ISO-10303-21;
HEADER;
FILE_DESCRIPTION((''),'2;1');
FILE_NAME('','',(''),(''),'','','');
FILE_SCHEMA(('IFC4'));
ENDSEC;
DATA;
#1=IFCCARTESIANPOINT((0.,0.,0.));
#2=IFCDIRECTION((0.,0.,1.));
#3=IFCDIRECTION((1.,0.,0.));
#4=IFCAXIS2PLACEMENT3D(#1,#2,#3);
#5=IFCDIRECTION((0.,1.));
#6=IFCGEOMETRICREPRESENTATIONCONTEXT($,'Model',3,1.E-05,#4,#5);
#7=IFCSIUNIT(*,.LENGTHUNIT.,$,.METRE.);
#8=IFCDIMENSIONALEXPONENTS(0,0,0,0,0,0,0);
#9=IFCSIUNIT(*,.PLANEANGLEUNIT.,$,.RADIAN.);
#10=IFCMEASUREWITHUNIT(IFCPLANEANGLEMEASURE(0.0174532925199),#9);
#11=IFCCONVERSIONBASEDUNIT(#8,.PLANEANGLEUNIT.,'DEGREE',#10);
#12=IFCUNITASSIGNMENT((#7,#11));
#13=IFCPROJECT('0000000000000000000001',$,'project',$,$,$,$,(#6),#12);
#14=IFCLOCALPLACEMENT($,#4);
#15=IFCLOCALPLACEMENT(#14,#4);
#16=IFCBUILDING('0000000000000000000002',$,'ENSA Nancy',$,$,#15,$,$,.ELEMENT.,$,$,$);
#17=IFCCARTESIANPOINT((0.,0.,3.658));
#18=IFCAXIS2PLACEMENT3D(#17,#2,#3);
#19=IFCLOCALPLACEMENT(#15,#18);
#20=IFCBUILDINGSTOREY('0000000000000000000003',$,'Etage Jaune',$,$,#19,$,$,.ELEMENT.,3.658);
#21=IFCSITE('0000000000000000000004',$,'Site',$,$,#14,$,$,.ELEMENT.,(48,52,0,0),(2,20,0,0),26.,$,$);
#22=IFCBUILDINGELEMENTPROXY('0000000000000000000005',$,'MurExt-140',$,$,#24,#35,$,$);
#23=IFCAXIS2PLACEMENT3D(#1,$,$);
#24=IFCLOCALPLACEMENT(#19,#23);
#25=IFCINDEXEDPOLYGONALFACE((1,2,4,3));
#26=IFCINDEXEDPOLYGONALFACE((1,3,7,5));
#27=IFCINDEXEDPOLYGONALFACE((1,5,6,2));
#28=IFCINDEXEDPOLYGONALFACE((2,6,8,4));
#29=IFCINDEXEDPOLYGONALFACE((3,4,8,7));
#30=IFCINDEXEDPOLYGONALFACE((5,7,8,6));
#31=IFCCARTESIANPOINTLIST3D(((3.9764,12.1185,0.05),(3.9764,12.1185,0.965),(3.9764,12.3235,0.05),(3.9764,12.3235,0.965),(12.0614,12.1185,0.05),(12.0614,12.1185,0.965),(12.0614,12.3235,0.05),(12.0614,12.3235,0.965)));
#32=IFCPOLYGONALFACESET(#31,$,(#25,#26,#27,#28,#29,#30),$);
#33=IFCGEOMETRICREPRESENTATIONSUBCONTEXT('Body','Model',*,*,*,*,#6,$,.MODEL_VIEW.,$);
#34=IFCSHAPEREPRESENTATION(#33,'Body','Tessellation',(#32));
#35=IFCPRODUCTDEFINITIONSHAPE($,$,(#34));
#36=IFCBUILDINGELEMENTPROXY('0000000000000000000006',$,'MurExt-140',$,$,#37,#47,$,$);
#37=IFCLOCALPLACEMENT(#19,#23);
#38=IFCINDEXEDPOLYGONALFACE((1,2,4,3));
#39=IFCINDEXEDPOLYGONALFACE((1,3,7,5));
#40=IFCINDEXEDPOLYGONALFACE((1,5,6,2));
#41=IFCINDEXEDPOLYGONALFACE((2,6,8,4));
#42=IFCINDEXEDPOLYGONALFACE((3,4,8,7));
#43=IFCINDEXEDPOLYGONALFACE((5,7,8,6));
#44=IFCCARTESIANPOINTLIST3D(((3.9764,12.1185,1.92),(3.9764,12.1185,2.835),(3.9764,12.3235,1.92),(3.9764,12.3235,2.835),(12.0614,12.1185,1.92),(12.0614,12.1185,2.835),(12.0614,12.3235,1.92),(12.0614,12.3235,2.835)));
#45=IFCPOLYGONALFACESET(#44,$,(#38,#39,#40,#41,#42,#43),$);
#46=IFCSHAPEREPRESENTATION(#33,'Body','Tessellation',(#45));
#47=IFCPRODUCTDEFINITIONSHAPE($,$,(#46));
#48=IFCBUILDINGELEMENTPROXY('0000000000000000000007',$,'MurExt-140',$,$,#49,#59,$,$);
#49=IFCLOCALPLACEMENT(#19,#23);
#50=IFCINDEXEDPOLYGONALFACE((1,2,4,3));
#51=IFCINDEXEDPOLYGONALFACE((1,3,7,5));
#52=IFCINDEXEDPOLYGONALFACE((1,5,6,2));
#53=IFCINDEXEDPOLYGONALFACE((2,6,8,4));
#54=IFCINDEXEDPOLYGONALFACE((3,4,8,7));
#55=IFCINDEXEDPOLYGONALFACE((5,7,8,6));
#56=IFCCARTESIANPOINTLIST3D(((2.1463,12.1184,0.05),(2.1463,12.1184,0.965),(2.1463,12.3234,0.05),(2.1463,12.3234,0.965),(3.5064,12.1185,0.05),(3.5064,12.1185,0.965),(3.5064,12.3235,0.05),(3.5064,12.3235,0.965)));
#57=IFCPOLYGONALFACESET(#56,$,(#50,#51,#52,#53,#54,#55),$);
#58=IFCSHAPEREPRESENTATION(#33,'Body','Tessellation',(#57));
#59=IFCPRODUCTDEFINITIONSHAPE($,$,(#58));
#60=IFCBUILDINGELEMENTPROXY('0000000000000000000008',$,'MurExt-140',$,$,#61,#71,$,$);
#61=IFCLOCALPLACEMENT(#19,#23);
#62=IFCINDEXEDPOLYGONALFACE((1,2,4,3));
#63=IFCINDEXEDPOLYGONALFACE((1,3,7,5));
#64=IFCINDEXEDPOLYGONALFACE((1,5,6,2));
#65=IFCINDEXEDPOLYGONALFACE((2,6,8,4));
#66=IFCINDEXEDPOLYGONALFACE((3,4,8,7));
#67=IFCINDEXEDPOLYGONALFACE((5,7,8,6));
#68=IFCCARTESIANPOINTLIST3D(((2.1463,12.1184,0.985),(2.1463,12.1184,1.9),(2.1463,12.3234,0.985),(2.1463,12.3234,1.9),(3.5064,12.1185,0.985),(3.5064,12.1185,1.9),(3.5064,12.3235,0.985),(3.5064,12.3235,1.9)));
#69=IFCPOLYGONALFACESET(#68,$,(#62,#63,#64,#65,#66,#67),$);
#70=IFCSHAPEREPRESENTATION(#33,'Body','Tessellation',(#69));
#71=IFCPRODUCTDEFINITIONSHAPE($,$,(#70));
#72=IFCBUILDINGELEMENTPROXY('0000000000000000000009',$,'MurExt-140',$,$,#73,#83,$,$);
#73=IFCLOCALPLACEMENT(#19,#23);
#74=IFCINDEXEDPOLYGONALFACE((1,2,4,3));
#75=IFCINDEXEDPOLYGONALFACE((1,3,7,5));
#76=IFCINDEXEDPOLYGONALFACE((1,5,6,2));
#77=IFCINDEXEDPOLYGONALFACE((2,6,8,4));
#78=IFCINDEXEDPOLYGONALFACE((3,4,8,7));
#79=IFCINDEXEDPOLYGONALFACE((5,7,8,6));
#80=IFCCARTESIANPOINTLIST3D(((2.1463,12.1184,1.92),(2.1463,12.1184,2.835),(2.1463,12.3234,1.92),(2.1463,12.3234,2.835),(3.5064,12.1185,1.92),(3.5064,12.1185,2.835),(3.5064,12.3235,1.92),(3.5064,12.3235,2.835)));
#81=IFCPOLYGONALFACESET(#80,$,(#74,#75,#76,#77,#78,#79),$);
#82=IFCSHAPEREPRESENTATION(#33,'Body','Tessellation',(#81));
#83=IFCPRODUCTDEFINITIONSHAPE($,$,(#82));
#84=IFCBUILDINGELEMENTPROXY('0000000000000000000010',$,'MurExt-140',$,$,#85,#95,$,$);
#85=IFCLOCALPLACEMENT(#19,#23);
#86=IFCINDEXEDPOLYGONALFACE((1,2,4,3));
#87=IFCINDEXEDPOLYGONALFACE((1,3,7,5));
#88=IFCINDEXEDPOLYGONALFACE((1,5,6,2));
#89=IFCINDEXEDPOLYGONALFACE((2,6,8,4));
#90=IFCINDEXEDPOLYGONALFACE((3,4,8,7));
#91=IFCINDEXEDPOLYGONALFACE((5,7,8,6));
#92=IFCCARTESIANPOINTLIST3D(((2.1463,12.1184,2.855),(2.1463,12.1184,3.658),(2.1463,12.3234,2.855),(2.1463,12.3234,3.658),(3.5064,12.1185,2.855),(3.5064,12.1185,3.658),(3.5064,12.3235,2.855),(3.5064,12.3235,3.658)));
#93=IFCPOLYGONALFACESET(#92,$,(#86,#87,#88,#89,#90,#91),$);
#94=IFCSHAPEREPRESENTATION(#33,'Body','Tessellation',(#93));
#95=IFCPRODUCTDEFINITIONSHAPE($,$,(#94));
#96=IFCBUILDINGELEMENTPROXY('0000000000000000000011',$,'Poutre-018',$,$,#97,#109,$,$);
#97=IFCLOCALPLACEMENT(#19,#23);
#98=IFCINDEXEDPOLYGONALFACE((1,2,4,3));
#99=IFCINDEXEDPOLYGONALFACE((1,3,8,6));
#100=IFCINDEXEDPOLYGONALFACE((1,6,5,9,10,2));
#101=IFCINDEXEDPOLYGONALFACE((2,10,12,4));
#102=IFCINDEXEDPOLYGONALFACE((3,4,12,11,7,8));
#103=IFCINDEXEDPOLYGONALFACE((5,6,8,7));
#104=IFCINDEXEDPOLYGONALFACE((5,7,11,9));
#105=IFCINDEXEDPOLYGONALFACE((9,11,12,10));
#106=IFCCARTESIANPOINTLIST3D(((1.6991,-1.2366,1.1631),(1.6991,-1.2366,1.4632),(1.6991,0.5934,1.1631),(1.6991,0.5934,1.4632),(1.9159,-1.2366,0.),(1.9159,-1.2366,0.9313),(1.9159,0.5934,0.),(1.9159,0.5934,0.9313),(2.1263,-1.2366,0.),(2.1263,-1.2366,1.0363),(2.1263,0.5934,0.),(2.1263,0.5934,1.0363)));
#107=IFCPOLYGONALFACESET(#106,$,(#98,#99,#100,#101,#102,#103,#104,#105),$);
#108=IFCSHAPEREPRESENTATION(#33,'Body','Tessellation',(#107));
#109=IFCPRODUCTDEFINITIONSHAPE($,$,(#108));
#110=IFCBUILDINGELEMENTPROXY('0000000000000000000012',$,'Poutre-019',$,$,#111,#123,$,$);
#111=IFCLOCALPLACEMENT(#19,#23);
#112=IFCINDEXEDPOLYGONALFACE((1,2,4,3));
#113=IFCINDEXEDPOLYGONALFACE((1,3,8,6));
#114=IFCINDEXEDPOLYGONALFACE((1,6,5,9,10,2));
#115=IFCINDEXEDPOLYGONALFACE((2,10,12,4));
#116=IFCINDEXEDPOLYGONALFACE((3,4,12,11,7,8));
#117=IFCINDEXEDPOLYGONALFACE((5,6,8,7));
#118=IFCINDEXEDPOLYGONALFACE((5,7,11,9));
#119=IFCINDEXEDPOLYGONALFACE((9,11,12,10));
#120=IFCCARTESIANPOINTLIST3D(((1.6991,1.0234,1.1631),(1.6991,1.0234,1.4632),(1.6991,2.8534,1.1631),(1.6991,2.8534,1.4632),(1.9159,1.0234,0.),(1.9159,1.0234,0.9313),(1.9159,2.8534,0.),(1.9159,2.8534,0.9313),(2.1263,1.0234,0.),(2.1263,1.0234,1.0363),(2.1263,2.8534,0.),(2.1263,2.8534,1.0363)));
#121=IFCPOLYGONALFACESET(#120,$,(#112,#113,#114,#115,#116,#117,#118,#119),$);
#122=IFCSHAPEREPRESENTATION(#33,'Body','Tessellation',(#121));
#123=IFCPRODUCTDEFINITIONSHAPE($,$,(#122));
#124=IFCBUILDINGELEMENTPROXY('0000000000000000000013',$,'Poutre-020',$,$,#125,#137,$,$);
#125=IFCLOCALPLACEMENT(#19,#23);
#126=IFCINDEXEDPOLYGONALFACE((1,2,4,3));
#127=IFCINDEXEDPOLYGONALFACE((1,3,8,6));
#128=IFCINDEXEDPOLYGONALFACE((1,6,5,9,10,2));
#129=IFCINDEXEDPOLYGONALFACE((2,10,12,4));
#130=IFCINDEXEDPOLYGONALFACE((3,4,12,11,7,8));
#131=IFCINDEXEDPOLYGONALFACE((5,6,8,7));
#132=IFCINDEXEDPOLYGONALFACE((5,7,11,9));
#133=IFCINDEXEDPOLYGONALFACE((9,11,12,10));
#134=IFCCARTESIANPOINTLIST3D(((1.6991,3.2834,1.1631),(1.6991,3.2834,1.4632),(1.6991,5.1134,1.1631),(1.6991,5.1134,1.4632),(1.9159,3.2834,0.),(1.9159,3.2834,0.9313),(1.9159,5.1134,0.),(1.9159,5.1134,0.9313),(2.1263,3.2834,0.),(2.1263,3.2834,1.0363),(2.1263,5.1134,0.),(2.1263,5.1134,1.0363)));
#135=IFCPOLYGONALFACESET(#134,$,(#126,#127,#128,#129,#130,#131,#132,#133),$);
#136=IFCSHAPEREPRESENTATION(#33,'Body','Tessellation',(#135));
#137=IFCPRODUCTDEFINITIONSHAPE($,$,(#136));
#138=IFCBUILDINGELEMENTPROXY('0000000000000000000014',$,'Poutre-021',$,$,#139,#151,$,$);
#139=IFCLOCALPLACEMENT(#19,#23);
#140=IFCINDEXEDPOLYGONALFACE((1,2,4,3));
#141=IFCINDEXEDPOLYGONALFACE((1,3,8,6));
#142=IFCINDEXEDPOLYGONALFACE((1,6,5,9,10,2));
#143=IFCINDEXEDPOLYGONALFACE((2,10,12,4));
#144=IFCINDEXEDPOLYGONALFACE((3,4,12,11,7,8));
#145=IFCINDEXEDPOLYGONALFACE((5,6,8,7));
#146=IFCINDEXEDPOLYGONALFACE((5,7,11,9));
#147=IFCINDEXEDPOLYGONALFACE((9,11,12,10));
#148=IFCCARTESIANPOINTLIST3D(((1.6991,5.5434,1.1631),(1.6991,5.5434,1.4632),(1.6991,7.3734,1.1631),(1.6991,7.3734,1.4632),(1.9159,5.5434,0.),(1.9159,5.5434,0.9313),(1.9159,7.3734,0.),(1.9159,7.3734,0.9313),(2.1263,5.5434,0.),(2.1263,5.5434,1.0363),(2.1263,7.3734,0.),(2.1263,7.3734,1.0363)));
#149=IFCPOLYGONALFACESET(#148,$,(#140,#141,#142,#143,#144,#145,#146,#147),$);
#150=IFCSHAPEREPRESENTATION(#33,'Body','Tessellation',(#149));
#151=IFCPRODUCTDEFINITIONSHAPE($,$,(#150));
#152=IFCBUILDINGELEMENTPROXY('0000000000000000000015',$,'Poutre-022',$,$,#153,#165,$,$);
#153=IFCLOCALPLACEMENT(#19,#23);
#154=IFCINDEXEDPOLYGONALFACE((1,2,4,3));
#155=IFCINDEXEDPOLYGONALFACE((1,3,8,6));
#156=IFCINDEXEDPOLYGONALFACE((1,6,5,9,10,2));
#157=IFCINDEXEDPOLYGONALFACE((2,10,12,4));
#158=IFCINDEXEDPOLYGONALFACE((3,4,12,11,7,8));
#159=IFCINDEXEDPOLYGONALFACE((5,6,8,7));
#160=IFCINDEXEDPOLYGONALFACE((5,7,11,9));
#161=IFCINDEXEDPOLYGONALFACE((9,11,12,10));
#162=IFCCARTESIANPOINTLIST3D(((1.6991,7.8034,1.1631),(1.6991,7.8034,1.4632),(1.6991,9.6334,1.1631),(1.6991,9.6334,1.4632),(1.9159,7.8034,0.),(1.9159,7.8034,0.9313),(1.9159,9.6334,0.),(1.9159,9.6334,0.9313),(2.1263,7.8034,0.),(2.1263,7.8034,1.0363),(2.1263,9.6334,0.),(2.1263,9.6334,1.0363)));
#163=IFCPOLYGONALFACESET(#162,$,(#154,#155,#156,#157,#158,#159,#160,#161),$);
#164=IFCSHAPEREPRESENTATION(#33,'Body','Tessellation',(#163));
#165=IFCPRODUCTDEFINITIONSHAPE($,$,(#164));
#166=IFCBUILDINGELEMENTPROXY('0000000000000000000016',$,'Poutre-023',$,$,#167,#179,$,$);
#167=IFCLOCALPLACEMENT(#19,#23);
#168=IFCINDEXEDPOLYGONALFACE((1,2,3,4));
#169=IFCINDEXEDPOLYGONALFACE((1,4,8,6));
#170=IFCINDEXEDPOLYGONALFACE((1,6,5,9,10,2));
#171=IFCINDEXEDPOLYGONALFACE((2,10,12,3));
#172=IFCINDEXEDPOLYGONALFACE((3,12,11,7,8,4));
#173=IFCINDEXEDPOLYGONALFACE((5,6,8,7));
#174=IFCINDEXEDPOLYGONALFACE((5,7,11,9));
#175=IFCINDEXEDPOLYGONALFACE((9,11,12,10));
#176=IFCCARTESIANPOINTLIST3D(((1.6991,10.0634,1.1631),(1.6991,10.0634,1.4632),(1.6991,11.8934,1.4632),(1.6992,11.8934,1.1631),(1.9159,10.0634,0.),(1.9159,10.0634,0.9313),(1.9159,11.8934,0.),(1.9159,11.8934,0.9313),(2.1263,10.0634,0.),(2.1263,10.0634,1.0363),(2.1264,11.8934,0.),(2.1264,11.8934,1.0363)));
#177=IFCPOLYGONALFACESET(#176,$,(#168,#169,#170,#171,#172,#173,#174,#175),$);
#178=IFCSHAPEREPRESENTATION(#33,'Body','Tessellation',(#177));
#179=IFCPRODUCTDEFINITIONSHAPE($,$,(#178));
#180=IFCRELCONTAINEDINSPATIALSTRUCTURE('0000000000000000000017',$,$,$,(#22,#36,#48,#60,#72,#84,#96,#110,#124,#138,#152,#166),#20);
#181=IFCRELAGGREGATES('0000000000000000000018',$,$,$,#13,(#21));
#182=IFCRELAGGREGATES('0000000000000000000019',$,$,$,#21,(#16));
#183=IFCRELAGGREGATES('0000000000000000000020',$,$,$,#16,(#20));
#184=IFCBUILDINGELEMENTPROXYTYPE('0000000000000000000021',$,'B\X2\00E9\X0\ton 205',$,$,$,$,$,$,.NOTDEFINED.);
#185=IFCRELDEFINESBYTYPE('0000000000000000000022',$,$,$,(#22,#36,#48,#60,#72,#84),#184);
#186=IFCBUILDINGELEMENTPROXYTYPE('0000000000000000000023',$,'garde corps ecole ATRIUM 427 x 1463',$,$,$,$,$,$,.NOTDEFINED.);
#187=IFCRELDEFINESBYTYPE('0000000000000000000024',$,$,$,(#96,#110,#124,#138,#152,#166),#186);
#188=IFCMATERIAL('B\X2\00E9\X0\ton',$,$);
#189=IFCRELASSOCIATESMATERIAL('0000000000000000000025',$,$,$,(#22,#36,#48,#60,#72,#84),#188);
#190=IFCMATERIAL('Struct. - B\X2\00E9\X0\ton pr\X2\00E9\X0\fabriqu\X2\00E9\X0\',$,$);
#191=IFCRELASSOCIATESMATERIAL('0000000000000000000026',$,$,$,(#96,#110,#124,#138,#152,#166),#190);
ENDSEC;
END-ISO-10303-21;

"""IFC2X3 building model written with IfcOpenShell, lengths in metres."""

from ifc_helpers import new_model, entity, si_unit, converted_unit, direction, frame, origin_with_axes, place, context, subcontext, project, spatial, polyline, outline, extrude, material, type_object, element, save


model = new_model("IFC2X3")

# Units and contexts
model_context = context("Model", 3, precision=1e-05, world=origin_with_axes(), true_north=direction((0.0, 1.0)))
body_context = subcontext(model_context, "Body", "Model", "MODEL_VIEW")
ifc_project = project(units=[si_unit("LENGTHUNIT", "METRE"), converted_unit("PLANEANGLEUNIT", "DEGREE", entity("IfcPlaneAngleMeasure", 0.0174532925199), si_unit("PLANEANGLEUNIT", "RADIAN"), dimensions=[0, 0, 0, 0, 0, 0, 0])], contexts=[model_context])

# Site, building, storey
site_placement = place(None, origin_with_axes())
site = spatial("IfcSite", under=ifc_project, at=site_placement, Name="Site", CompositionType="ELEMENT", RefLatitude=(48, 52, 0, 0), RefLongitude=(2, 20, 0, 0), RefElevation=26.0)
building_placement = place(site_placement, origin_with_axes())
building = spatial("IfcBuilding", under=site, at=building_placement, Name="ENSA Nancy", CompositionType="ELEMENT")
storey_placement = place(building_placement, frame((0.0, 0.0, 3.658), z_axis=(0.0, 0.0, 1.0), x_axis=(1.0, 0.0, 0.0)))
storey = spatial("IfcBuildingStorey", under=building, at=storey_placement, Name="Etage Jaune", CompositionType="ELEMENT", Elevation=3.658)

# Building element proxies
ifc_material_1 = material(Name="Béton")
building_element_proxy_type_1 = type_object("IfcBuildingElementProxyType", Name="Béton 205", PredefinedType="NOTDEFINED")
for number, where, z_axis, x_axis, name in (
    (1, (3.9764, 12.3235, 0.05), (0.0, 0.0, 1.0), (1.0, 0.0, 0.0), "MurExt-140"),
    (2, (3.9764, 12.3235, 1.92), (0.0, 0.0, 1.0), (1.0, 0.0, 0.0), "MurExt-140"),
):
    element("IfcBuildingElementProxy", number, at=place(storey_placement, frame(where, z_axis=z_axis, x_axis=x_axis)), inside=storey, type_object=building_element_proxy_type_1, material=ifc_material_1, Name=name, context=body_context, shape_type="SweptSolid", body=[
        extrude(outline(polyline([(0.0, -0.205), (8.085, -0.205), (8.085, 0.0), (0.0, 0.0), (0.0, -0.205)])), origin_with_axes(), (0.0, 0.0, 1.0), 0.915),
    ])
for number, where, z_axis, x_axis, name in (
    (3, (2.1463, 12.3234, 0.05), (0.0, 0.0, 1.0), (1.0, 0.000034, 0.0), "MurExt-140"),
    (4, (2.1463, 12.3234, 0.985), (0.0, 0.0, 1.0), (1.0, 0.000034, 0.0), "MurExt-140"),
    (5, (2.1463, 12.3234, 1.92), (0.0, 0.0, 1.0), (1.0, 0.000034, 0.0), "MurExt-140"),
):
    element("IfcBuildingElementProxy", number, at=place(storey_placement, frame(where, z_axis=z_axis, x_axis=x_axis)), inside=storey, type_object=building_element_proxy_type_1, material=ifc_material_1, Name=name, context=body_context, shape_type="SweptSolid", body=[
        extrude(outline(polyline([(0.0, -0.205), (1.3601, -0.205), (1.3601, 0.0), (0.0, 0.0), (0.0, -0.205)])), origin_with_axes(), (0.0, 0.0, 1.0), 0.915),
    ])
proxy_1_placement = place(storey_placement, frame((2.1463, 12.3234, 2.855), z_axis=(0.0, 0.0, 1.0), x_axis=(1.0, 0.000034, 0.0)))
element("IfcBuildingElementProxy", 6, at=proxy_1_placement, inside=storey, type_object=building_element_proxy_type_1, material=ifc_material_1, Name="MurExt-140", context=body_context, shape_type="SweptSolid", body=[
    extrude(outline(polyline([(0.0, -0.205), (1.3601, -0.205), (1.3601, 0.0), (0.0, 0.0), (0.0, -0.205)])), origin_with_axes(), (0.0, 0.0, 1.0), 0.803),
])
ifc_material_2 = material(Name="Struct. - Béton préfabriqué")
building_element_proxy_type_2 = type_object("IfcBuildingElementProxyType", Name="garde corps ecole ATRIUM 427 x 1463", PredefinedType="NOTDEFINED")
proxy_2_placement = place(storey_placement, frame((2.1263, -1.2366, 0.0), z_axis=(0.0, 0.0, 1.0), x_axis=(1.0, 0.0, 0.0)))
element("IfcBuildingElementProxy", 7, at=proxy_2_placement, inside=storey, type_object=building_element_proxy_type_2, material=ifc_material_2, Name="Poutre-018", context=body_context, shape_type="SweptSolid", body=[
    extrude(outline(polyline([(0.0, 1.0363), (0.0, 0.0), (0.2105, 0.0), (0.2105, 0.9313), (0.4272, 1.1631), (0.4272, 1.4632), (0.0, 1.0363)])), frame((0.0, 1.83, 0.0), z_axis=(0.0, 1.0, 0.0), x_axis=(-1.0, 0.0, 0.0)), (0.0, 0.0, -1.0), 1.83),
])
proxy_3_placement = place(storey_placement, frame((2.1263, 1.0234, 0.0), z_axis=(0.0, 0.0, 1.0), x_axis=(1.0, 0.0, 0.0)))
element("IfcBuildingElementProxy", 8, at=proxy_3_placement, inside=storey, type_object=building_element_proxy_type_2, material=ifc_material_2, Name="Poutre-019", context=body_context, shape_type="SweptSolid", body=[
    extrude(outline(polyline([(0.0, 1.0363), (0.0, 0.0), (0.2105, 0.0), (0.2105, 0.9313), (0.4272, 1.1631), (0.4272, 1.4632), (0.0, 1.0363)])), frame((0.0, 1.83, 0.0), z_axis=(0.0, 1.0, 0.0), x_axis=(-1.0, 0.0, 0.0)), (0.0, 0.0, -1.0), 1.83),
])
proxy_4_placement = place(storey_placement, frame((2.1263, 3.2834, 0.0), z_axis=(0.0, 0.0, 1.0), x_axis=(1.0, 0.0, 0.0)))
element("IfcBuildingElementProxy", 9, at=proxy_4_placement, inside=storey, type_object=building_element_proxy_type_2, material=ifc_material_2, Name="Poutre-020", context=body_context, shape_type="SweptSolid", body=[
    extrude(outline(polyline([(0.0, 1.0363), (0.0, 0.0), (0.2105, 0.0), (0.2105, 0.9313), (0.4272, 1.1631), (0.4272, 1.4632), (0.0, 1.0363)])), frame((0.0, 1.83, 0.0), z_axis=(0.0, 1.0, 0.0), x_axis=(-1.0, 0.0, 0.0)), (0.0, 0.0, -1.0), 1.83),
])
proxy_5_placement = place(storey_placement, frame((2.1263, 5.5434, 0.0), z_axis=(0.0, 0.0, 1.0), x_axis=(1.0, 0.0, 0.0)))
element("IfcBuildingElementProxy", 10, at=proxy_5_placement, inside=storey, type_object=building_element_proxy_type_2, material=ifc_material_2, Name="Poutre-021", context=body_context, shape_type="SweptSolid", body=[
    extrude(outline(polyline([(0.0, 1.0363), (0.0, 0.0), (0.2105, 0.0), (0.2105, 0.9313), (0.4272, 1.1631), (0.4272, 1.4632), (0.0, 1.0363)])), frame((0.0, 1.83, 0.0), z_axis=(0.0, 1.0, 0.0), x_axis=(-1.0, 0.0, 0.0)), (0.0, 0.0, -1.0), 1.83),
])
proxy_6_placement = place(storey_placement, frame((2.1263, 7.8034, 0.0), z_axis=(0.0, 0.0, 1.0), x_axis=(1.0, 0.0, 0.0)))
element("IfcBuildingElementProxy", 11, at=proxy_6_placement, inside=storey, type_object=building_element_proxy_type_2, material=ifc_material_2, Name="Poutre-022", context=body_context, shape_type="SweptSolid", body=[
    extrude(outline(polyline([(0.0, 1.0363), (0.0, 0.0), (0.2105, 0.0), (0.2105, 0.9313), (0.4272, 1.1631), (0.4272, 1.4632), (0.0, 1.0363)])), frame((0.0, 1.83, 0.0), z_axis=(0.0, 1.0, 0.0), x_axis=(-1.0, 0.0, 0.0)), (0.0, 0.0, -1.0), 1.83),
])
proxy_7_placement = place(storey_placement, frame((2.1263, 10.0634, 0.0), z_axis=(0.0, 0.0, 1.0), x_axis=(1.0, -0.000024, 0.0)))
element("IfcBuildingElementProxy", 12, at=proxy_7_placement, inside=storey, type_object=building_element_proxy_type_2, material=ifc_material_2, Name="Poutre-023", context=body_context, shape_type="SweptSolid", body=[
    extrude(outline(polyline([(0.0, 1.0363), (0.0, 0.0), (0.2105, 0.0), (0.2105, 0.9313), (0.4272, 1.1631), (0.4272, 1.4632), (0.0, 1.0363)])), frame((0.0, 1.83, 0.0), z_axis=(0.0, 1.0, 0.0), x_axis=(-1.0, 0.0, 0.0)), (0.0, 0.0, -1.0), 1.83),
])

save(model, "model.ifc")
